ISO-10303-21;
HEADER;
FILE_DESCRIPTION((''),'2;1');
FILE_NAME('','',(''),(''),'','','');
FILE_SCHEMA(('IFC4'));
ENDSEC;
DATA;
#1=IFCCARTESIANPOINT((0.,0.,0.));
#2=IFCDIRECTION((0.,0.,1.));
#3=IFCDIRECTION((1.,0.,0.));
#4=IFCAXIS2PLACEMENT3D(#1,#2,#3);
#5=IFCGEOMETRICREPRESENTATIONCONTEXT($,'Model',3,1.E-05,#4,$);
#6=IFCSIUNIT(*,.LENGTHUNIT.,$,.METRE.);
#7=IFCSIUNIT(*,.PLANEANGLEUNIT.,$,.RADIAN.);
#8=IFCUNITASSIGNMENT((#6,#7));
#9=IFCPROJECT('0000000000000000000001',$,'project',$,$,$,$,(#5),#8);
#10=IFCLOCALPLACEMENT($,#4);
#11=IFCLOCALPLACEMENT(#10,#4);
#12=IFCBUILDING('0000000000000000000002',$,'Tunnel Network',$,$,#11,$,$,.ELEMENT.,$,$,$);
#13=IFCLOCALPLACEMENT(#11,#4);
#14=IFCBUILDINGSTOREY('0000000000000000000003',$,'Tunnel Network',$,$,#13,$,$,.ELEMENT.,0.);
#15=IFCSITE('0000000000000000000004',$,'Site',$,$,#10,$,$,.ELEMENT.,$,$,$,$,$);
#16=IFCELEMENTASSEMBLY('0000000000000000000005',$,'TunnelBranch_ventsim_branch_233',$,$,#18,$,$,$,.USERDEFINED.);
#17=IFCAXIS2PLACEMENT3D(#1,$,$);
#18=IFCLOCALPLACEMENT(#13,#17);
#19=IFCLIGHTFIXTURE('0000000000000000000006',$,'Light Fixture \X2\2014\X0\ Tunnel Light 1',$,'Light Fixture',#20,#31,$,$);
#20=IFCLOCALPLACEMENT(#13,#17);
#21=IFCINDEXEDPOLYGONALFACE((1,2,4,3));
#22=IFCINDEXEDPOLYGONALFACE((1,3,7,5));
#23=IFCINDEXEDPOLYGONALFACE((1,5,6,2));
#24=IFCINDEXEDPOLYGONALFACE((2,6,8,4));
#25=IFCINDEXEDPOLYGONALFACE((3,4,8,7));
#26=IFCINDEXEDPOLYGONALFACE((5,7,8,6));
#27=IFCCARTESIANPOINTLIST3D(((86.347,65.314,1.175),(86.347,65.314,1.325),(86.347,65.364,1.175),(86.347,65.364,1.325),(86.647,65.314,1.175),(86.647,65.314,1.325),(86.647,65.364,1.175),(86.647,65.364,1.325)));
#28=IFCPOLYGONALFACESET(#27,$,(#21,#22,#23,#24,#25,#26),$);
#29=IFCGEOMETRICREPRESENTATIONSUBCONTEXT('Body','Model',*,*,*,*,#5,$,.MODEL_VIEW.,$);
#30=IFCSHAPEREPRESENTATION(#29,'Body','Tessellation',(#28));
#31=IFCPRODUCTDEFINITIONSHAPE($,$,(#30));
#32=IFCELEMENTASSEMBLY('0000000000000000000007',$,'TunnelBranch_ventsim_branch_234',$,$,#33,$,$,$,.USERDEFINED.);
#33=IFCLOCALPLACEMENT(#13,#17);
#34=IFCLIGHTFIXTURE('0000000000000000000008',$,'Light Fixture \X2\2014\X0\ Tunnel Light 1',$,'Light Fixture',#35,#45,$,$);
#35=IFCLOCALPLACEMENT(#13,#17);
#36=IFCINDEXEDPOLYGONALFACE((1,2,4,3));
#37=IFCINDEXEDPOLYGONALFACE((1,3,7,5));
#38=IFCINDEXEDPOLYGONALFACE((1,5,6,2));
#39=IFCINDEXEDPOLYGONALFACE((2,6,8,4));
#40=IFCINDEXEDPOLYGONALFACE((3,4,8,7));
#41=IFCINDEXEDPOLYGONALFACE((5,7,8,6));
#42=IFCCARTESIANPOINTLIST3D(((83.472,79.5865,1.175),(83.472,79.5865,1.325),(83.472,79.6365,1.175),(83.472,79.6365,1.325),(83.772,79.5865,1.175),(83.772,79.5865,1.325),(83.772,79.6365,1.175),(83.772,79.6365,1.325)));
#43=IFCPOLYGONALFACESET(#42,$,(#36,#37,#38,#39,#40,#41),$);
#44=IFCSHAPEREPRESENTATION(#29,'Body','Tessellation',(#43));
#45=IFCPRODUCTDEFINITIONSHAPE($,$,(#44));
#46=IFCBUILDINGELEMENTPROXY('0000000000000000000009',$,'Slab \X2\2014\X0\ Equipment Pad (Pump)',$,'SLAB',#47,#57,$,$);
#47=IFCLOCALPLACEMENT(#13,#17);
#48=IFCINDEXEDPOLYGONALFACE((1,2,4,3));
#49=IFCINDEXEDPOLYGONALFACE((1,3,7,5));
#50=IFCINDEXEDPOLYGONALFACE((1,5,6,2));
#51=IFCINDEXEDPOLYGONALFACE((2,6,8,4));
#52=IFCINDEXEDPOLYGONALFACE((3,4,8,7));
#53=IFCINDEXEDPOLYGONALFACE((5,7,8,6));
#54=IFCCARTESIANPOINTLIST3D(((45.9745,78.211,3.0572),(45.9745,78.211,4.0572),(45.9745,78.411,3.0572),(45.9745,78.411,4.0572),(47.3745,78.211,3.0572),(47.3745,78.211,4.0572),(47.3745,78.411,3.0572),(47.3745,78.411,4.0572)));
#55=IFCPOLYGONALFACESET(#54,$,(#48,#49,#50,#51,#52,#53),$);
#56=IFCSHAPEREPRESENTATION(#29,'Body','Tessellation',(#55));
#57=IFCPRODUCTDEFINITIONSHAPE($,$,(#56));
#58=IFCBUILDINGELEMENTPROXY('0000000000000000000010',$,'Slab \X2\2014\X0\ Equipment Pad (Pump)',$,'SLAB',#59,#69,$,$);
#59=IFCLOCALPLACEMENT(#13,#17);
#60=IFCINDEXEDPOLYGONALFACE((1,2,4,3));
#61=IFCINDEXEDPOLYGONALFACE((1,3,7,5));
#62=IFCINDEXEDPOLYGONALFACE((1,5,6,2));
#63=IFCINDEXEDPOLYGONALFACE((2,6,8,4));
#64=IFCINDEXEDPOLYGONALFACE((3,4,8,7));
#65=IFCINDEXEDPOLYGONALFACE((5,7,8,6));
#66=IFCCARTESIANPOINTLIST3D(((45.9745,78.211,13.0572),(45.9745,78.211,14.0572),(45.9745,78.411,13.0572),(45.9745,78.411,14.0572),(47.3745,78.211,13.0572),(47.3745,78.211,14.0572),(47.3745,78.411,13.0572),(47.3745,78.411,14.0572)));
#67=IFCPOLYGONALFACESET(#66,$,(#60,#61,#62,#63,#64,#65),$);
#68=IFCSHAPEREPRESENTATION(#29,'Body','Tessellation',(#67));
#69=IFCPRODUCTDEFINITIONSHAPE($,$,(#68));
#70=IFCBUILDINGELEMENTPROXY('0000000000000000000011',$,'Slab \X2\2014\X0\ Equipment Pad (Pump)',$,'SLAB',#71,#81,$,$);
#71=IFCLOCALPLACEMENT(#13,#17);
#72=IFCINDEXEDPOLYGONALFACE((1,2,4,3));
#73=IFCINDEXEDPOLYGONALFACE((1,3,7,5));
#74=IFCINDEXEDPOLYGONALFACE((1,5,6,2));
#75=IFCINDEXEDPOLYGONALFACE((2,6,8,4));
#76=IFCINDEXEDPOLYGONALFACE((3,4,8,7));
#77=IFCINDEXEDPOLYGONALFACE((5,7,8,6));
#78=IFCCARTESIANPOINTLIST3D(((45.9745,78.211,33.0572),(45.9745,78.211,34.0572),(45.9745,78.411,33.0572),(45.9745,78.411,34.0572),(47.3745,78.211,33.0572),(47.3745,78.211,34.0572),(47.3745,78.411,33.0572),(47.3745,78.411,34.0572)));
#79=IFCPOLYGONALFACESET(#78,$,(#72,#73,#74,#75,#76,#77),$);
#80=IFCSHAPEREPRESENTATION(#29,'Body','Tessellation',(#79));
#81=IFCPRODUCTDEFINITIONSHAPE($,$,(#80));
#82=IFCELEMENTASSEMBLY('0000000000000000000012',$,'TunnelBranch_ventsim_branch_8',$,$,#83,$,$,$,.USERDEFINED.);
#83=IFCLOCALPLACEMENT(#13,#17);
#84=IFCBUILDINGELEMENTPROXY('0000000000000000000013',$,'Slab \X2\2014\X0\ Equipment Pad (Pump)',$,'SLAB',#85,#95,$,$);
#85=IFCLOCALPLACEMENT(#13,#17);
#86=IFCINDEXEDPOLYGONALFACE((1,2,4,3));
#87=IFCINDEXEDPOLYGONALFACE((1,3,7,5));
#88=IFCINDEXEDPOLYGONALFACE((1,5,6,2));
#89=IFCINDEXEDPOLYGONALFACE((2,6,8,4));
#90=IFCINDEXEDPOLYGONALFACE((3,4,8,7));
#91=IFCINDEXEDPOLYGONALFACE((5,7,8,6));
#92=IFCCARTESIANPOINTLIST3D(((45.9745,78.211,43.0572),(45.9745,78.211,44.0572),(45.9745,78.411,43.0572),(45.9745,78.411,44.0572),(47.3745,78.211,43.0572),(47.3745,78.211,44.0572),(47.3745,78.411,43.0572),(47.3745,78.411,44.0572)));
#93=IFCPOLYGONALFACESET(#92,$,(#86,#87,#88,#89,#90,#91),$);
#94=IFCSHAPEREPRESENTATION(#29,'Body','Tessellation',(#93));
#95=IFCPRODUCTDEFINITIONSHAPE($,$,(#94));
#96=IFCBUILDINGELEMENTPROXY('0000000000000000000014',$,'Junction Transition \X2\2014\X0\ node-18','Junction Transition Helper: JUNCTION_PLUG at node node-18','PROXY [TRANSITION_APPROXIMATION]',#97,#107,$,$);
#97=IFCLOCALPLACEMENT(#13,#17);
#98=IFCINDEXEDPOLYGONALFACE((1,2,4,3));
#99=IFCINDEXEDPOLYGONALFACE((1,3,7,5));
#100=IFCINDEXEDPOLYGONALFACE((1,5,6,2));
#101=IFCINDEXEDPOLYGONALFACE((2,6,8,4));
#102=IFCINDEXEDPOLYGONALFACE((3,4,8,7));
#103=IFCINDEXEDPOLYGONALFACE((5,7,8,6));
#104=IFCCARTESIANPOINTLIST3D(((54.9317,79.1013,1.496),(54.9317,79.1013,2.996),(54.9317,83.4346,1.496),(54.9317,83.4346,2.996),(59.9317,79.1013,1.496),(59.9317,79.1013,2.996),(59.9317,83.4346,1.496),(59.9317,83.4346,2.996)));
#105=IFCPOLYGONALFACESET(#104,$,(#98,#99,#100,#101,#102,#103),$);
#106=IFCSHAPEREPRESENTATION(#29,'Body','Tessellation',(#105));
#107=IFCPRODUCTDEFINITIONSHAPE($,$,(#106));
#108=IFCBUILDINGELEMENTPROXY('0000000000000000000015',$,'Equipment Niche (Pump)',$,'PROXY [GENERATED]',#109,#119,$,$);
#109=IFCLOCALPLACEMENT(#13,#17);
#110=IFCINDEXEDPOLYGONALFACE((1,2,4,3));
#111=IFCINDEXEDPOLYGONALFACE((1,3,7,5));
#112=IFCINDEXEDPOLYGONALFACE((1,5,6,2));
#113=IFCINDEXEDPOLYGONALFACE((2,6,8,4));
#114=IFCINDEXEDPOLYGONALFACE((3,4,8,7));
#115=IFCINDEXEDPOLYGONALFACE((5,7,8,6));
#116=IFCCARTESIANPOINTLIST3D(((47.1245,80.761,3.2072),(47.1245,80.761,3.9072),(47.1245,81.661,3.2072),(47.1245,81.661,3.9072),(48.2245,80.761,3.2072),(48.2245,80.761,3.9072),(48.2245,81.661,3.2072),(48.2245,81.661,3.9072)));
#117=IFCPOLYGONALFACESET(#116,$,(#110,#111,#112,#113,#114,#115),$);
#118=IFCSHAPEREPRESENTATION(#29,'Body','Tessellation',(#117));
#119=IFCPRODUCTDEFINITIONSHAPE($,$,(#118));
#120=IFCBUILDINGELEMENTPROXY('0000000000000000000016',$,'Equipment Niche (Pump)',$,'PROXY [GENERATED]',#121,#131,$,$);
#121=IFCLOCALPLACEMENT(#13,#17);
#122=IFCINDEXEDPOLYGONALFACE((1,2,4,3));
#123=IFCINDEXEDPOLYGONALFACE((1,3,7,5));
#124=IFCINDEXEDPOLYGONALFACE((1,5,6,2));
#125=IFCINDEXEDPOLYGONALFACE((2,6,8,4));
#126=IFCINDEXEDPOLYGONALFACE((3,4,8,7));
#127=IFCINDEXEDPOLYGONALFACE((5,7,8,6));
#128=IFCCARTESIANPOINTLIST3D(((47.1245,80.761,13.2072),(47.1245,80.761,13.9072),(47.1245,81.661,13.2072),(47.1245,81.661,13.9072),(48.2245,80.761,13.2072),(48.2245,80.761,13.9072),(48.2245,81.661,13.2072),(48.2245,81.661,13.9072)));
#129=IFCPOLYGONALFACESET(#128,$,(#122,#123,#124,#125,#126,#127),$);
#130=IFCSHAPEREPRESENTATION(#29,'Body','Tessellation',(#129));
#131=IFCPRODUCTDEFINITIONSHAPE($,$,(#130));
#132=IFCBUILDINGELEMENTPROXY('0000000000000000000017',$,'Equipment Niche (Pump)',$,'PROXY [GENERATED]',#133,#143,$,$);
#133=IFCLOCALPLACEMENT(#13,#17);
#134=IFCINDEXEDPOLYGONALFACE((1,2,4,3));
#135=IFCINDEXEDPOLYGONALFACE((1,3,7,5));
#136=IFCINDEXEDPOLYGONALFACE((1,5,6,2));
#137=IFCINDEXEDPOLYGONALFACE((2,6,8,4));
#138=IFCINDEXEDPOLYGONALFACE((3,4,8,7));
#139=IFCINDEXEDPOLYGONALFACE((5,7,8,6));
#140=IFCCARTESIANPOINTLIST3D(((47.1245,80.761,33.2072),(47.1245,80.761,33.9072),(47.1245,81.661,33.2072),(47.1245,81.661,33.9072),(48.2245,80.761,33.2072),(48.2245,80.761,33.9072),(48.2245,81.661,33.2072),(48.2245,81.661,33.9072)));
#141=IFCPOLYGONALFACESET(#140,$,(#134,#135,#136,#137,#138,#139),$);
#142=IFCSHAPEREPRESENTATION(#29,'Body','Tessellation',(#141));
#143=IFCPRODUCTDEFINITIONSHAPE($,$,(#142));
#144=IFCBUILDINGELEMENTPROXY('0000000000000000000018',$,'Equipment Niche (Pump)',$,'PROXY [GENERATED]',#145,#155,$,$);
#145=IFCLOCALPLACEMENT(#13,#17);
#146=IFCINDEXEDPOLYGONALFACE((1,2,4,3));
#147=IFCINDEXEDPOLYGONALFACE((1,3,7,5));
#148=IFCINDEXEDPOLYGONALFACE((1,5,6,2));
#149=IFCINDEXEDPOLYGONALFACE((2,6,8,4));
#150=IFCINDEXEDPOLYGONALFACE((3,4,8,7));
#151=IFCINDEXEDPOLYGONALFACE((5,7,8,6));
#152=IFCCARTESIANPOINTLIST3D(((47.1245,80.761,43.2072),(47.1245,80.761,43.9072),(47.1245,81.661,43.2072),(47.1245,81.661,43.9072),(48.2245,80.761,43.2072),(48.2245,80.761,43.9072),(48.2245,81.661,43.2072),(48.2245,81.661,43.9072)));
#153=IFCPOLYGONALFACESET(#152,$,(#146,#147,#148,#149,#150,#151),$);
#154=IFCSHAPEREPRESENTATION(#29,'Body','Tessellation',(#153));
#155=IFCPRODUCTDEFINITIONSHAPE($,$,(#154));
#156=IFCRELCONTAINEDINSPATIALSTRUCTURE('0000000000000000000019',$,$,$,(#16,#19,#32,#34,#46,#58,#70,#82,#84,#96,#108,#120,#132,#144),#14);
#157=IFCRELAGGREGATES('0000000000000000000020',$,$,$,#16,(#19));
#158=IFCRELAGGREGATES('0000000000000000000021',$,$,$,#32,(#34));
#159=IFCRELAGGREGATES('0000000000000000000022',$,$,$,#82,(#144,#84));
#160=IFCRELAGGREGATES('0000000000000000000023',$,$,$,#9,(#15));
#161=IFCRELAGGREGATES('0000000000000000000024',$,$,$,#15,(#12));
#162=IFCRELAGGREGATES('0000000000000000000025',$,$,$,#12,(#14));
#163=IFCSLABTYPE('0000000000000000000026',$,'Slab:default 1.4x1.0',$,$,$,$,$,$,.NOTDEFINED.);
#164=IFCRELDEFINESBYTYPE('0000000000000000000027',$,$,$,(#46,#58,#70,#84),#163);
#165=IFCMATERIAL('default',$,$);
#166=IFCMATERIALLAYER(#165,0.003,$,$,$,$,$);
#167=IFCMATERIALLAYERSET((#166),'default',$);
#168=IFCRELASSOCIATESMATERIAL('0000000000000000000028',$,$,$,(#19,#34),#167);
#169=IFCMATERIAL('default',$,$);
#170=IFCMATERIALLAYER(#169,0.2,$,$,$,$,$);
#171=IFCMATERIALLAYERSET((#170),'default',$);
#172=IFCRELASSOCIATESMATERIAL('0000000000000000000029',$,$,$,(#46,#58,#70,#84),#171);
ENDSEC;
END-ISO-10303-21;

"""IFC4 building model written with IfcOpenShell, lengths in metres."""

from ifc_helpers import new_model, si_unit, frame, origin_with_axes, origin_2d_with_axis, place, context, subcontext, project, spatial, rectangle, extrude, material, layer, layer_set, layer_usage, type_object, element, aggregate, save


model = new_model("IFC4")

# Units and contexts
model_context = context("Model", 3, precision=1e-05, world=origin_with_axes())
body_context = subcontext(model_context, "Body", "Model", "MODEL_VIEW")
ifc_project = project(units=[si_unit("LENGTHUNIT", "METRE"), si_unit("PLANEANGLEUNIT", "RADIAN")], contexts=[model_context])

# Site, building, storey
site_placement = place(None, origin_with_axes())
site = spatial("IfcSite", under=ifc_project, at=site_placement, Name="Site", CompositionType="ELEMENT")
building_placement = place(site_placement, origin_with_axes())
building = spatial("IfcBuilding", under=site, at=building_placement, Name="Tunnel Network", CompositionType="ELEMENT")
storey_placement = place(building_placement, origin_with_axes())
storey = spatial("IfcBuildingStorey", under=building, at=storey_placement, Name="Tunnel Network", CompositionType="ELEMENT", Elevation=0.0)

# Shared definitions
ifc_material_1 = material(Name="default")
ifc_layer_1 = layer(ifc_material_1, 0.003)
ifc_layer_set_1 = layer_set([ifc_layer_1], Name="default")

# Element assemblies, light fixtures
assembly_1_placement = place(storey_placement, frame((86.497, 65.314, 1.25), z_axis=(0.0, 1.0, 0.0), x_axis=(-1.0, 0.0, 0.0)))
assembly_1 = element("IfcElementAssembly", 1, at=assembly_1_placement, inside=storey, Name="TunnelBranch_ventsim_branch_233", PredefinedType="USERDEFINED")
ifc_layer_usage_1 = layer_usage(ifc_layer_set_1, "AXIS2", "POSITIVE", 0.0)
light_fixture_1_placement = place(storey_placement, frame((86.497, 65.314, 1.25), z_axis=(0.0, 1.0, 0.0), x_axis=(-1.0, 0.0, 0.0)))
light_fixture_1 = element("IfcLightFixture", 2, at=light_fixture_1_placement, inside=storey, material=ifc_layer_usage_1, Name="Light Fixture — Tunnel Light 1", ObjectType="Light Fixture", context=body_context, shape_type="SweptSolid", body=[
    extrude(rectangle(XDim=0.3, YDim=0.15, at=origin_2d_with_axis()), origin_with_axes(), (0.0, 0.0, 1.0), 0.05),
])
aggregate(assembly_1, [light_fixture_1])
assembly_2_placement = place(storey_placement, frame((83.622, 79.5865, 1.25), z_axis=(0.0, 1.0, 0.0), x_axis=(-1.0, 0.0, 0.0)))
assembly_2 = element("IfcElementAssembly", 3, at=assembly_2_placement, inside=storey, Name="TunnelBranch_ventsim_branch_234", PredefinedType="USERDEFINED")
ifc_layer_usage_2 = layer_usage(ifc_layer_set_1, "AXIS2", "POSITIVE", 0.0)
light_fixture_2_placement = place(storey_placement, frame((83.622, 79.5865, 1.25), z_axis=(0.0, 1.0, 0.0), x_axis=(-1.0, 0.0, 0.0)))
light_fixture_2 = element("IfcLightFixture", 4, at=light_fixture_2_placement, inside=storey, material=ifc_layer_usage_2, Name="Light Fixture — Tunnel Light 1", ObjectType="Light Fixture", context=body_context, shape_type="SweptSolid", body=[
    extrude(rectangle(XDim=0.3, YDim=0.15, at=origin_2d_with_axis()), origin_with_axes(), (0.0, 0.0, 1.0), 0.05),
])
aggregate(assembly_2, [light_fixture_2])

# Building element proxies
ifc_material_2 = material(Name="default")
ifc_layer_2 = layer(ifc_material_2, 0.2)
ifc_layer_set_2 = layer_set([ifc_layer_2], Name="default")
ifc_layer_usage_3 = layer_usage(ifc_layer_set_2, "AXIS3", "POSITIVE", 0.0)
slab_type = type_object("IfcSlabType", Name="Slab:default 1.4x1.0")
proxy_1_placement = place(storey_placement, frame((46.6745, 78.411, 3.5572), z_axis=(0.0, 1.0, 0.0), x_axis=(-1.0, 0.0, 0.0)))
element("IfcBuildingElementProxy", 5, at=proxy_1_placement, inside=storey, type_object=slab_type, material=ifc_layer_usage_3, Name="Slab — Equipment Pad (Pump)", ObjectType="SLAB", context=body_context, shape_type="SweptSolid", body=[
    extrude(rectangle(XDim=1.4, YDim=1.0, at=origin_2d_with_axis()), frame((0.0, 0.0, 0.0), z_axis=(0.0, 0.0, -1.0), x_axis=(1.0, 0.0, 0.0)), (0.0, 0.0, 1.0), 0.2),
])
ifc_layer_usage_4 = layer_usage(ifc_layer_set_2, "AXIS3", "POSITIVE", 0.0)
proxy_2_placement = place(storey_placement, frame((46.6745, 78.411, 13.5572), z_axis=(0.0, 1.0, 0.0), x_axis=(-1.0, 0.0, 0.0)))
element("IfcBuildingElementProxy", 6, at=proxy_2_placement, inside=storey, type_object=slab_type, material=ifc_layer_usage_4, Name="Slab — Equipment Pad (Pump)", ObjectType="SLAB", context=body_context, shape_type="SweptSolid", body=[
    extrude(rectangle(XDim=1.4, YDim=1.0, at=origin_2d_with_axis()), frame((0.0, 0.0, 0.0), z_axis=(0.0, 0.0, -1.0), x_axis=(1.0, 0.0, 0.0)), (0.0, 0.0, 1.0), 0.2),
])
ifc_layer_usage_5 = layer_usage(ifc_layer_set_2, "AXIS3", "POSITIVE", 0.0)
proxy_3_placement = place(storey_placement, frame((46.6745, 78.411, 33.5572), z_axis=(0.0, 1.0, 0.0), x_axis=(-1.0, 0.0, 0.0)))
element("IfcBuildingElementProxy", 7, at=proxy_3_placement, inside=storey, type_object=slab_type, material=ifc_layer_usage_5, Name="Slab — Equipment Pad (Pump)", ObjectType="SLAB", context=body_context, shape_type="SweptSolid", body=[
    extrude(rectangle(XDim=1.4, YDim=1.0, at=origin_2d_with_axis()), frame((0.0, 0.0, 0.0), z_axis=(0.0, 0.0, -1.0), x_axis=(1.0, 0.0, 0.0)), (0.0, 0.0, 1.0), 0.2),
])

# Element assembly, building element proxy
assembly_3_placement = place(storey_placement, frame((47.6745, 80.761, 43.5572), z_axis=(0.0, 1.0, 0.0), x_axis=(-1.0, 0.0, 0.0)))
assembly_3 = element("IfcElementAssembly", 8, at=assembly_3_placement, inside=storey, Name="TunnelBranch_ventsim_branch_8", PredefinedType="USERDEFINED")
ifc_layer_usage_6 = layer_usage(ifc_layer_set_2, "AXIS3", "POSITIVE", 0.0)
proxy_4_placement = place(storey_placement, frame((46.6745, 78.411, 43.5572), z_axis=(0.0, 1.0, 0.0), x_axis=(-1.0, 0.0, 0.0)))
proxy_4 = element("IfcBuildingElementProxy", 9, at=proxy_4_placement, inside=storey, type_object=slab_type, material=ifc_layer_usage_6, Name="Slab — Equipment Pad (Pump)", ObjectType="SLAB", context=body_context, shape_type="SweptSolid", body=[
    extrude(rectangle(XDim=1.4, YDim=1.0, at=origin_2d_with_axis()), frame((0.0, 0.0, 0.0), z_axis=(0.0, 0.0, -1.0), x_axis=(1.0, 0.0, 0.0)), (0.0, 0.0, 1.0), 0.2),
])

# Building element proxies
proxy_5_placement = place(storey_placement, frame((57.4317, 81.268, 1.496), z_axis=(0.0, 0.0, 1.0), x_axis=(1.0, 0.0, 0.0)))
element("IfcBuildingElementProxy", 10, at=proxy_5_placement, inside=storey, Name="Junction Transition — node-18", Description="Junction Transition Helper: JUNCTION_PLUG at node node-18", ObjectType="PROXY [TRANSITION_APPROXIMATION]", context=body_context, shape_type="SweptSolid", body=[
    extrude(rectangle(XDim=5.0, YDim=4.3333, at=origin_2d_with_axis()), origin_with_axes(), (0.0, 0.0, 1.0), 1.5),
])
for number, where, z_axis, x_axis, name in (
    (11, (47.6745, 80.761, 3.5572), (0.0, 1.0, 0.0), (-1.0, 0.0, 0.0), "Equipment Niche (Pump)"),
    (12, (47.6745, 80.761, 13.5572), (0.0, 1.0, 0.0), (-1.0, 0.0, 0.0), "Equipment Niche (Pump)"),
    (13, (47.6745, 80.761, 33.5572), (0.0, 1.0, 0.0), (-1.0, 0.0, 0.0), "Equipment Niche (Pump)"),
):
    element("IfcBuildingElementProxy", number, at=place(storey_placement, frame(where, z_axis=z_axis, x_axis=x_axis)), inside=storey, Name=name, ObjectType="PROXY [GENERATED]", context=body_context, shape_type="SweptSolid", body=[
        extrude(rectangle(XDim=1.1, YDim=0.7, at=origin_2d_with_axis()), origin_with_axes(), (0.0, 0.0, 1.0), 0.9),
    ])

# Building element proxy
proxy_6_placement = place(storey_placement, frame((47.6745, 80.761, 43.5572), z_axis=(0.0, 1.0, 0.0), x_axis=(-1.0, 0.0, 0.0)))
proxy_6 = element("IfcBuildingElementProxy", 14, at=proxy_6_placement, inside=storey, Name="Equipment Niche (Pump)", ObjectType="PROXY [GENERATED]", context=body_context, shape_type="SweptSolid", body=[
    extrude(rectangle(XDim=1.1, YDim=0.7, at=origin_2d_with_axis()), origin_with_axes(), (0.0, 0.0, 1.0), 0.9),
])
aggregate(assembly_3, [proxy_6, proxy_4])

save(model, "model.ifc")
